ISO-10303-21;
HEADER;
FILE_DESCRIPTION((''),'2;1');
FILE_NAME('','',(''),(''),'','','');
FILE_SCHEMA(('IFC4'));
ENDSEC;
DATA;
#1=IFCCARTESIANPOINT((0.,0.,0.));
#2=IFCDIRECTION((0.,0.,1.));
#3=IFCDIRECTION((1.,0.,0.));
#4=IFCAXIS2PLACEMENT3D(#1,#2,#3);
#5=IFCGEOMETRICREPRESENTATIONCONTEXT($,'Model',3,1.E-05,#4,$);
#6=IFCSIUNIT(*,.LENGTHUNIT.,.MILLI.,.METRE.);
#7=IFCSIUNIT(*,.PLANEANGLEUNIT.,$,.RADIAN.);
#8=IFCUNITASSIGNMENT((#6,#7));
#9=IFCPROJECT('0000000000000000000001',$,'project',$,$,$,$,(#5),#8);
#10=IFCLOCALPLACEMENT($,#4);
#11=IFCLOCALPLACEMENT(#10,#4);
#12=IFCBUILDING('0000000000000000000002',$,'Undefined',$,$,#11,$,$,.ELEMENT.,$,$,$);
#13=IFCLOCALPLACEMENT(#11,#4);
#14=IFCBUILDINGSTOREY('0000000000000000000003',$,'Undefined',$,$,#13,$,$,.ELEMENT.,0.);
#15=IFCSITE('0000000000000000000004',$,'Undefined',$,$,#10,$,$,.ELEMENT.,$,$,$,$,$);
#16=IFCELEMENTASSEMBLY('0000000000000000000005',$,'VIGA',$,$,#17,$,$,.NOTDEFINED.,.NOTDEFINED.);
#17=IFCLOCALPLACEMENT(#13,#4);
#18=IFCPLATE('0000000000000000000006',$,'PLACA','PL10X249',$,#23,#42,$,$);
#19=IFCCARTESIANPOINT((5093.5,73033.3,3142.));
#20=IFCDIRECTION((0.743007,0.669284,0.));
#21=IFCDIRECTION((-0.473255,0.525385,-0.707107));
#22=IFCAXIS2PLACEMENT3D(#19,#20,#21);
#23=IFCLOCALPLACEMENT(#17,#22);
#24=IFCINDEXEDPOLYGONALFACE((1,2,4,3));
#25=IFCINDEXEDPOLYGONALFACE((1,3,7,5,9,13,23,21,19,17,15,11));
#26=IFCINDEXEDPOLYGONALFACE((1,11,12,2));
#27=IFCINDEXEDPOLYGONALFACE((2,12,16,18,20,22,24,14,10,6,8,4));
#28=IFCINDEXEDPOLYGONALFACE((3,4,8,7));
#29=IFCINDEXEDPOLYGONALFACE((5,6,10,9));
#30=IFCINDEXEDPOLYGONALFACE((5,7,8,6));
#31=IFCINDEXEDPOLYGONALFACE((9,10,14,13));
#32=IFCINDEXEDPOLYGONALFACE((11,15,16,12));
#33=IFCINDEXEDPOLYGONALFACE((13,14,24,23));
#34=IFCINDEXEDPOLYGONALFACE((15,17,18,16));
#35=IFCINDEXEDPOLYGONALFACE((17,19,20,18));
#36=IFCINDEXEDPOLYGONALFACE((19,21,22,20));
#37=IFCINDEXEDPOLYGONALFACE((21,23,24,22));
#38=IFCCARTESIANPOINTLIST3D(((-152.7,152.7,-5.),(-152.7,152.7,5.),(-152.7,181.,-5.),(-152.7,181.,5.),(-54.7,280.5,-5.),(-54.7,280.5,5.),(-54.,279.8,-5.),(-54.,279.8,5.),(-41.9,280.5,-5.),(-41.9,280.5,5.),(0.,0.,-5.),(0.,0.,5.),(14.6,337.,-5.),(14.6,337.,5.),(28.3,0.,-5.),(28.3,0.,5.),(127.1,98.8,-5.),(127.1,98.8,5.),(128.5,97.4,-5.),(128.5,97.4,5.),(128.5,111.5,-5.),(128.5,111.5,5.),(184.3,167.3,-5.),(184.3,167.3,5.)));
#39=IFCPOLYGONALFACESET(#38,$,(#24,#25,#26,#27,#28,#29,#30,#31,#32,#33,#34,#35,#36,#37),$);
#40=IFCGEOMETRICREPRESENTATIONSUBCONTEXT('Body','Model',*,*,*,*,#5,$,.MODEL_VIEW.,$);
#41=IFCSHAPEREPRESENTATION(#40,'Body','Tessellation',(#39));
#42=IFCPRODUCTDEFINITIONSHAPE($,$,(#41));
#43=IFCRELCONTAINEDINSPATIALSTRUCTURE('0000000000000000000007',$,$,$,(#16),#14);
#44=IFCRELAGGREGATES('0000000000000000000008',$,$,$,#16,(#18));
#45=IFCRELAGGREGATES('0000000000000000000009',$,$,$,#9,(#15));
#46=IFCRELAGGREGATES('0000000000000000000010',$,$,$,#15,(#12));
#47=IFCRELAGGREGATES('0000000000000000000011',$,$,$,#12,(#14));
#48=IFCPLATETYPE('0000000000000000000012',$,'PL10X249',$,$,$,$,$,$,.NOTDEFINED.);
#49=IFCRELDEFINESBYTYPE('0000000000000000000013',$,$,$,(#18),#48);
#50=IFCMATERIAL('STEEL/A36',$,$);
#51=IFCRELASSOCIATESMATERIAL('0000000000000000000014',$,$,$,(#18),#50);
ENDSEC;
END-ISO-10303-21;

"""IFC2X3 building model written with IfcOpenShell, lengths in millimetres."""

from ifc_helpers import new_model, si_unit, frame, origin_with_axes, place, context, subcontext, project, spatial, polyline, outline, extrude, material, type_object, element, aggregate, save


model = new_model("IFC2X3")

# Units and contexts
model_context = context("Model", 3, precision=1e-05, world=origin_with_axes())
body_context = subcontext(model_context, "Body", "Model", "MODEL_VIEW")
ifc_project = project(units=[si_unit("LENGTHUNIT", "METRE", prefix="MILLI"), si_unit("PLANEANGLEUNIT", "RADIAN")], contexts=[model_context])

# Site, building, storey
site_placement = place(None, origin_with_axes())
site = spatial("IfcSite", under=ifc_project, at=site_placement, Name="Undefined", CompositionType="ELEMENT")
building_placement = place(site_placement, origin_with_axes())
building = spatial("IfcBuilding", under=site, at=building_placement, Name="Undefined", CompositionType="ELEMENT")
storey_placement = place(building_placement, origin_with_axes())
storey = spatial("IfcBuildingStorey", under=building, at=storey_placement, Name="Undefined", CompositionType="ELEMENT", Elevation=0.0)

# Element assembly
assembly_1_placement = place(storey_placement, origin_with_axes())
assembly_1 = element("IfcElementAssembly", 1, at=assembly_1_placement, inside=storey, Name="VIGA", AssemblyPlace="NOTDEFINED", PredefinedType="NOTDEFINED")
ifc_material_1 = material(Name="STEEL/A36")

# Plate
plate_type_1 = type_object("IfcPlateType", Name="PL10X249", PredefinedType="NOTDEFINED")
plate_1_placement = place(assembly_1_placement, frame((5093.5, 73033.3, 3142.0), z_axis=(0.743007, 0.669284, 0.0), x_axis=(-0.473255, 0.525385, -0.707107)))
plate_1 = element("IfcPlate", 2, at=plate_1_placement, type_object=plate_type_1, material=ifc_material_1, Name="PLACA", Description="PL10X249", context=body_context, shape_type="SweptSolid", body=[
    extrude(outline(polyline([(0.0, 0.0), (28.3, 0.0), (127.1, 98.8), (128.5, 97.4), (128.5, 111.5), (184.3, 167.3), (14.6, 337.0), (-41.9, 280.5), (-54.7, 280.5), (-54.0, 279.8), (-152.7, 181.0), (-152.7, 152.7), (0.0, 0.0)])), frame((0.0, 0.0, -5.0), z_axis=(0.0, 0.0, 1.0), x_axis=(1.0, 0.0, 0.0)), (0.0, 0.0, 1.0), 10.0),
])
aggregate(assembly_1, [plate_1])

save(model, "model.ifc")
